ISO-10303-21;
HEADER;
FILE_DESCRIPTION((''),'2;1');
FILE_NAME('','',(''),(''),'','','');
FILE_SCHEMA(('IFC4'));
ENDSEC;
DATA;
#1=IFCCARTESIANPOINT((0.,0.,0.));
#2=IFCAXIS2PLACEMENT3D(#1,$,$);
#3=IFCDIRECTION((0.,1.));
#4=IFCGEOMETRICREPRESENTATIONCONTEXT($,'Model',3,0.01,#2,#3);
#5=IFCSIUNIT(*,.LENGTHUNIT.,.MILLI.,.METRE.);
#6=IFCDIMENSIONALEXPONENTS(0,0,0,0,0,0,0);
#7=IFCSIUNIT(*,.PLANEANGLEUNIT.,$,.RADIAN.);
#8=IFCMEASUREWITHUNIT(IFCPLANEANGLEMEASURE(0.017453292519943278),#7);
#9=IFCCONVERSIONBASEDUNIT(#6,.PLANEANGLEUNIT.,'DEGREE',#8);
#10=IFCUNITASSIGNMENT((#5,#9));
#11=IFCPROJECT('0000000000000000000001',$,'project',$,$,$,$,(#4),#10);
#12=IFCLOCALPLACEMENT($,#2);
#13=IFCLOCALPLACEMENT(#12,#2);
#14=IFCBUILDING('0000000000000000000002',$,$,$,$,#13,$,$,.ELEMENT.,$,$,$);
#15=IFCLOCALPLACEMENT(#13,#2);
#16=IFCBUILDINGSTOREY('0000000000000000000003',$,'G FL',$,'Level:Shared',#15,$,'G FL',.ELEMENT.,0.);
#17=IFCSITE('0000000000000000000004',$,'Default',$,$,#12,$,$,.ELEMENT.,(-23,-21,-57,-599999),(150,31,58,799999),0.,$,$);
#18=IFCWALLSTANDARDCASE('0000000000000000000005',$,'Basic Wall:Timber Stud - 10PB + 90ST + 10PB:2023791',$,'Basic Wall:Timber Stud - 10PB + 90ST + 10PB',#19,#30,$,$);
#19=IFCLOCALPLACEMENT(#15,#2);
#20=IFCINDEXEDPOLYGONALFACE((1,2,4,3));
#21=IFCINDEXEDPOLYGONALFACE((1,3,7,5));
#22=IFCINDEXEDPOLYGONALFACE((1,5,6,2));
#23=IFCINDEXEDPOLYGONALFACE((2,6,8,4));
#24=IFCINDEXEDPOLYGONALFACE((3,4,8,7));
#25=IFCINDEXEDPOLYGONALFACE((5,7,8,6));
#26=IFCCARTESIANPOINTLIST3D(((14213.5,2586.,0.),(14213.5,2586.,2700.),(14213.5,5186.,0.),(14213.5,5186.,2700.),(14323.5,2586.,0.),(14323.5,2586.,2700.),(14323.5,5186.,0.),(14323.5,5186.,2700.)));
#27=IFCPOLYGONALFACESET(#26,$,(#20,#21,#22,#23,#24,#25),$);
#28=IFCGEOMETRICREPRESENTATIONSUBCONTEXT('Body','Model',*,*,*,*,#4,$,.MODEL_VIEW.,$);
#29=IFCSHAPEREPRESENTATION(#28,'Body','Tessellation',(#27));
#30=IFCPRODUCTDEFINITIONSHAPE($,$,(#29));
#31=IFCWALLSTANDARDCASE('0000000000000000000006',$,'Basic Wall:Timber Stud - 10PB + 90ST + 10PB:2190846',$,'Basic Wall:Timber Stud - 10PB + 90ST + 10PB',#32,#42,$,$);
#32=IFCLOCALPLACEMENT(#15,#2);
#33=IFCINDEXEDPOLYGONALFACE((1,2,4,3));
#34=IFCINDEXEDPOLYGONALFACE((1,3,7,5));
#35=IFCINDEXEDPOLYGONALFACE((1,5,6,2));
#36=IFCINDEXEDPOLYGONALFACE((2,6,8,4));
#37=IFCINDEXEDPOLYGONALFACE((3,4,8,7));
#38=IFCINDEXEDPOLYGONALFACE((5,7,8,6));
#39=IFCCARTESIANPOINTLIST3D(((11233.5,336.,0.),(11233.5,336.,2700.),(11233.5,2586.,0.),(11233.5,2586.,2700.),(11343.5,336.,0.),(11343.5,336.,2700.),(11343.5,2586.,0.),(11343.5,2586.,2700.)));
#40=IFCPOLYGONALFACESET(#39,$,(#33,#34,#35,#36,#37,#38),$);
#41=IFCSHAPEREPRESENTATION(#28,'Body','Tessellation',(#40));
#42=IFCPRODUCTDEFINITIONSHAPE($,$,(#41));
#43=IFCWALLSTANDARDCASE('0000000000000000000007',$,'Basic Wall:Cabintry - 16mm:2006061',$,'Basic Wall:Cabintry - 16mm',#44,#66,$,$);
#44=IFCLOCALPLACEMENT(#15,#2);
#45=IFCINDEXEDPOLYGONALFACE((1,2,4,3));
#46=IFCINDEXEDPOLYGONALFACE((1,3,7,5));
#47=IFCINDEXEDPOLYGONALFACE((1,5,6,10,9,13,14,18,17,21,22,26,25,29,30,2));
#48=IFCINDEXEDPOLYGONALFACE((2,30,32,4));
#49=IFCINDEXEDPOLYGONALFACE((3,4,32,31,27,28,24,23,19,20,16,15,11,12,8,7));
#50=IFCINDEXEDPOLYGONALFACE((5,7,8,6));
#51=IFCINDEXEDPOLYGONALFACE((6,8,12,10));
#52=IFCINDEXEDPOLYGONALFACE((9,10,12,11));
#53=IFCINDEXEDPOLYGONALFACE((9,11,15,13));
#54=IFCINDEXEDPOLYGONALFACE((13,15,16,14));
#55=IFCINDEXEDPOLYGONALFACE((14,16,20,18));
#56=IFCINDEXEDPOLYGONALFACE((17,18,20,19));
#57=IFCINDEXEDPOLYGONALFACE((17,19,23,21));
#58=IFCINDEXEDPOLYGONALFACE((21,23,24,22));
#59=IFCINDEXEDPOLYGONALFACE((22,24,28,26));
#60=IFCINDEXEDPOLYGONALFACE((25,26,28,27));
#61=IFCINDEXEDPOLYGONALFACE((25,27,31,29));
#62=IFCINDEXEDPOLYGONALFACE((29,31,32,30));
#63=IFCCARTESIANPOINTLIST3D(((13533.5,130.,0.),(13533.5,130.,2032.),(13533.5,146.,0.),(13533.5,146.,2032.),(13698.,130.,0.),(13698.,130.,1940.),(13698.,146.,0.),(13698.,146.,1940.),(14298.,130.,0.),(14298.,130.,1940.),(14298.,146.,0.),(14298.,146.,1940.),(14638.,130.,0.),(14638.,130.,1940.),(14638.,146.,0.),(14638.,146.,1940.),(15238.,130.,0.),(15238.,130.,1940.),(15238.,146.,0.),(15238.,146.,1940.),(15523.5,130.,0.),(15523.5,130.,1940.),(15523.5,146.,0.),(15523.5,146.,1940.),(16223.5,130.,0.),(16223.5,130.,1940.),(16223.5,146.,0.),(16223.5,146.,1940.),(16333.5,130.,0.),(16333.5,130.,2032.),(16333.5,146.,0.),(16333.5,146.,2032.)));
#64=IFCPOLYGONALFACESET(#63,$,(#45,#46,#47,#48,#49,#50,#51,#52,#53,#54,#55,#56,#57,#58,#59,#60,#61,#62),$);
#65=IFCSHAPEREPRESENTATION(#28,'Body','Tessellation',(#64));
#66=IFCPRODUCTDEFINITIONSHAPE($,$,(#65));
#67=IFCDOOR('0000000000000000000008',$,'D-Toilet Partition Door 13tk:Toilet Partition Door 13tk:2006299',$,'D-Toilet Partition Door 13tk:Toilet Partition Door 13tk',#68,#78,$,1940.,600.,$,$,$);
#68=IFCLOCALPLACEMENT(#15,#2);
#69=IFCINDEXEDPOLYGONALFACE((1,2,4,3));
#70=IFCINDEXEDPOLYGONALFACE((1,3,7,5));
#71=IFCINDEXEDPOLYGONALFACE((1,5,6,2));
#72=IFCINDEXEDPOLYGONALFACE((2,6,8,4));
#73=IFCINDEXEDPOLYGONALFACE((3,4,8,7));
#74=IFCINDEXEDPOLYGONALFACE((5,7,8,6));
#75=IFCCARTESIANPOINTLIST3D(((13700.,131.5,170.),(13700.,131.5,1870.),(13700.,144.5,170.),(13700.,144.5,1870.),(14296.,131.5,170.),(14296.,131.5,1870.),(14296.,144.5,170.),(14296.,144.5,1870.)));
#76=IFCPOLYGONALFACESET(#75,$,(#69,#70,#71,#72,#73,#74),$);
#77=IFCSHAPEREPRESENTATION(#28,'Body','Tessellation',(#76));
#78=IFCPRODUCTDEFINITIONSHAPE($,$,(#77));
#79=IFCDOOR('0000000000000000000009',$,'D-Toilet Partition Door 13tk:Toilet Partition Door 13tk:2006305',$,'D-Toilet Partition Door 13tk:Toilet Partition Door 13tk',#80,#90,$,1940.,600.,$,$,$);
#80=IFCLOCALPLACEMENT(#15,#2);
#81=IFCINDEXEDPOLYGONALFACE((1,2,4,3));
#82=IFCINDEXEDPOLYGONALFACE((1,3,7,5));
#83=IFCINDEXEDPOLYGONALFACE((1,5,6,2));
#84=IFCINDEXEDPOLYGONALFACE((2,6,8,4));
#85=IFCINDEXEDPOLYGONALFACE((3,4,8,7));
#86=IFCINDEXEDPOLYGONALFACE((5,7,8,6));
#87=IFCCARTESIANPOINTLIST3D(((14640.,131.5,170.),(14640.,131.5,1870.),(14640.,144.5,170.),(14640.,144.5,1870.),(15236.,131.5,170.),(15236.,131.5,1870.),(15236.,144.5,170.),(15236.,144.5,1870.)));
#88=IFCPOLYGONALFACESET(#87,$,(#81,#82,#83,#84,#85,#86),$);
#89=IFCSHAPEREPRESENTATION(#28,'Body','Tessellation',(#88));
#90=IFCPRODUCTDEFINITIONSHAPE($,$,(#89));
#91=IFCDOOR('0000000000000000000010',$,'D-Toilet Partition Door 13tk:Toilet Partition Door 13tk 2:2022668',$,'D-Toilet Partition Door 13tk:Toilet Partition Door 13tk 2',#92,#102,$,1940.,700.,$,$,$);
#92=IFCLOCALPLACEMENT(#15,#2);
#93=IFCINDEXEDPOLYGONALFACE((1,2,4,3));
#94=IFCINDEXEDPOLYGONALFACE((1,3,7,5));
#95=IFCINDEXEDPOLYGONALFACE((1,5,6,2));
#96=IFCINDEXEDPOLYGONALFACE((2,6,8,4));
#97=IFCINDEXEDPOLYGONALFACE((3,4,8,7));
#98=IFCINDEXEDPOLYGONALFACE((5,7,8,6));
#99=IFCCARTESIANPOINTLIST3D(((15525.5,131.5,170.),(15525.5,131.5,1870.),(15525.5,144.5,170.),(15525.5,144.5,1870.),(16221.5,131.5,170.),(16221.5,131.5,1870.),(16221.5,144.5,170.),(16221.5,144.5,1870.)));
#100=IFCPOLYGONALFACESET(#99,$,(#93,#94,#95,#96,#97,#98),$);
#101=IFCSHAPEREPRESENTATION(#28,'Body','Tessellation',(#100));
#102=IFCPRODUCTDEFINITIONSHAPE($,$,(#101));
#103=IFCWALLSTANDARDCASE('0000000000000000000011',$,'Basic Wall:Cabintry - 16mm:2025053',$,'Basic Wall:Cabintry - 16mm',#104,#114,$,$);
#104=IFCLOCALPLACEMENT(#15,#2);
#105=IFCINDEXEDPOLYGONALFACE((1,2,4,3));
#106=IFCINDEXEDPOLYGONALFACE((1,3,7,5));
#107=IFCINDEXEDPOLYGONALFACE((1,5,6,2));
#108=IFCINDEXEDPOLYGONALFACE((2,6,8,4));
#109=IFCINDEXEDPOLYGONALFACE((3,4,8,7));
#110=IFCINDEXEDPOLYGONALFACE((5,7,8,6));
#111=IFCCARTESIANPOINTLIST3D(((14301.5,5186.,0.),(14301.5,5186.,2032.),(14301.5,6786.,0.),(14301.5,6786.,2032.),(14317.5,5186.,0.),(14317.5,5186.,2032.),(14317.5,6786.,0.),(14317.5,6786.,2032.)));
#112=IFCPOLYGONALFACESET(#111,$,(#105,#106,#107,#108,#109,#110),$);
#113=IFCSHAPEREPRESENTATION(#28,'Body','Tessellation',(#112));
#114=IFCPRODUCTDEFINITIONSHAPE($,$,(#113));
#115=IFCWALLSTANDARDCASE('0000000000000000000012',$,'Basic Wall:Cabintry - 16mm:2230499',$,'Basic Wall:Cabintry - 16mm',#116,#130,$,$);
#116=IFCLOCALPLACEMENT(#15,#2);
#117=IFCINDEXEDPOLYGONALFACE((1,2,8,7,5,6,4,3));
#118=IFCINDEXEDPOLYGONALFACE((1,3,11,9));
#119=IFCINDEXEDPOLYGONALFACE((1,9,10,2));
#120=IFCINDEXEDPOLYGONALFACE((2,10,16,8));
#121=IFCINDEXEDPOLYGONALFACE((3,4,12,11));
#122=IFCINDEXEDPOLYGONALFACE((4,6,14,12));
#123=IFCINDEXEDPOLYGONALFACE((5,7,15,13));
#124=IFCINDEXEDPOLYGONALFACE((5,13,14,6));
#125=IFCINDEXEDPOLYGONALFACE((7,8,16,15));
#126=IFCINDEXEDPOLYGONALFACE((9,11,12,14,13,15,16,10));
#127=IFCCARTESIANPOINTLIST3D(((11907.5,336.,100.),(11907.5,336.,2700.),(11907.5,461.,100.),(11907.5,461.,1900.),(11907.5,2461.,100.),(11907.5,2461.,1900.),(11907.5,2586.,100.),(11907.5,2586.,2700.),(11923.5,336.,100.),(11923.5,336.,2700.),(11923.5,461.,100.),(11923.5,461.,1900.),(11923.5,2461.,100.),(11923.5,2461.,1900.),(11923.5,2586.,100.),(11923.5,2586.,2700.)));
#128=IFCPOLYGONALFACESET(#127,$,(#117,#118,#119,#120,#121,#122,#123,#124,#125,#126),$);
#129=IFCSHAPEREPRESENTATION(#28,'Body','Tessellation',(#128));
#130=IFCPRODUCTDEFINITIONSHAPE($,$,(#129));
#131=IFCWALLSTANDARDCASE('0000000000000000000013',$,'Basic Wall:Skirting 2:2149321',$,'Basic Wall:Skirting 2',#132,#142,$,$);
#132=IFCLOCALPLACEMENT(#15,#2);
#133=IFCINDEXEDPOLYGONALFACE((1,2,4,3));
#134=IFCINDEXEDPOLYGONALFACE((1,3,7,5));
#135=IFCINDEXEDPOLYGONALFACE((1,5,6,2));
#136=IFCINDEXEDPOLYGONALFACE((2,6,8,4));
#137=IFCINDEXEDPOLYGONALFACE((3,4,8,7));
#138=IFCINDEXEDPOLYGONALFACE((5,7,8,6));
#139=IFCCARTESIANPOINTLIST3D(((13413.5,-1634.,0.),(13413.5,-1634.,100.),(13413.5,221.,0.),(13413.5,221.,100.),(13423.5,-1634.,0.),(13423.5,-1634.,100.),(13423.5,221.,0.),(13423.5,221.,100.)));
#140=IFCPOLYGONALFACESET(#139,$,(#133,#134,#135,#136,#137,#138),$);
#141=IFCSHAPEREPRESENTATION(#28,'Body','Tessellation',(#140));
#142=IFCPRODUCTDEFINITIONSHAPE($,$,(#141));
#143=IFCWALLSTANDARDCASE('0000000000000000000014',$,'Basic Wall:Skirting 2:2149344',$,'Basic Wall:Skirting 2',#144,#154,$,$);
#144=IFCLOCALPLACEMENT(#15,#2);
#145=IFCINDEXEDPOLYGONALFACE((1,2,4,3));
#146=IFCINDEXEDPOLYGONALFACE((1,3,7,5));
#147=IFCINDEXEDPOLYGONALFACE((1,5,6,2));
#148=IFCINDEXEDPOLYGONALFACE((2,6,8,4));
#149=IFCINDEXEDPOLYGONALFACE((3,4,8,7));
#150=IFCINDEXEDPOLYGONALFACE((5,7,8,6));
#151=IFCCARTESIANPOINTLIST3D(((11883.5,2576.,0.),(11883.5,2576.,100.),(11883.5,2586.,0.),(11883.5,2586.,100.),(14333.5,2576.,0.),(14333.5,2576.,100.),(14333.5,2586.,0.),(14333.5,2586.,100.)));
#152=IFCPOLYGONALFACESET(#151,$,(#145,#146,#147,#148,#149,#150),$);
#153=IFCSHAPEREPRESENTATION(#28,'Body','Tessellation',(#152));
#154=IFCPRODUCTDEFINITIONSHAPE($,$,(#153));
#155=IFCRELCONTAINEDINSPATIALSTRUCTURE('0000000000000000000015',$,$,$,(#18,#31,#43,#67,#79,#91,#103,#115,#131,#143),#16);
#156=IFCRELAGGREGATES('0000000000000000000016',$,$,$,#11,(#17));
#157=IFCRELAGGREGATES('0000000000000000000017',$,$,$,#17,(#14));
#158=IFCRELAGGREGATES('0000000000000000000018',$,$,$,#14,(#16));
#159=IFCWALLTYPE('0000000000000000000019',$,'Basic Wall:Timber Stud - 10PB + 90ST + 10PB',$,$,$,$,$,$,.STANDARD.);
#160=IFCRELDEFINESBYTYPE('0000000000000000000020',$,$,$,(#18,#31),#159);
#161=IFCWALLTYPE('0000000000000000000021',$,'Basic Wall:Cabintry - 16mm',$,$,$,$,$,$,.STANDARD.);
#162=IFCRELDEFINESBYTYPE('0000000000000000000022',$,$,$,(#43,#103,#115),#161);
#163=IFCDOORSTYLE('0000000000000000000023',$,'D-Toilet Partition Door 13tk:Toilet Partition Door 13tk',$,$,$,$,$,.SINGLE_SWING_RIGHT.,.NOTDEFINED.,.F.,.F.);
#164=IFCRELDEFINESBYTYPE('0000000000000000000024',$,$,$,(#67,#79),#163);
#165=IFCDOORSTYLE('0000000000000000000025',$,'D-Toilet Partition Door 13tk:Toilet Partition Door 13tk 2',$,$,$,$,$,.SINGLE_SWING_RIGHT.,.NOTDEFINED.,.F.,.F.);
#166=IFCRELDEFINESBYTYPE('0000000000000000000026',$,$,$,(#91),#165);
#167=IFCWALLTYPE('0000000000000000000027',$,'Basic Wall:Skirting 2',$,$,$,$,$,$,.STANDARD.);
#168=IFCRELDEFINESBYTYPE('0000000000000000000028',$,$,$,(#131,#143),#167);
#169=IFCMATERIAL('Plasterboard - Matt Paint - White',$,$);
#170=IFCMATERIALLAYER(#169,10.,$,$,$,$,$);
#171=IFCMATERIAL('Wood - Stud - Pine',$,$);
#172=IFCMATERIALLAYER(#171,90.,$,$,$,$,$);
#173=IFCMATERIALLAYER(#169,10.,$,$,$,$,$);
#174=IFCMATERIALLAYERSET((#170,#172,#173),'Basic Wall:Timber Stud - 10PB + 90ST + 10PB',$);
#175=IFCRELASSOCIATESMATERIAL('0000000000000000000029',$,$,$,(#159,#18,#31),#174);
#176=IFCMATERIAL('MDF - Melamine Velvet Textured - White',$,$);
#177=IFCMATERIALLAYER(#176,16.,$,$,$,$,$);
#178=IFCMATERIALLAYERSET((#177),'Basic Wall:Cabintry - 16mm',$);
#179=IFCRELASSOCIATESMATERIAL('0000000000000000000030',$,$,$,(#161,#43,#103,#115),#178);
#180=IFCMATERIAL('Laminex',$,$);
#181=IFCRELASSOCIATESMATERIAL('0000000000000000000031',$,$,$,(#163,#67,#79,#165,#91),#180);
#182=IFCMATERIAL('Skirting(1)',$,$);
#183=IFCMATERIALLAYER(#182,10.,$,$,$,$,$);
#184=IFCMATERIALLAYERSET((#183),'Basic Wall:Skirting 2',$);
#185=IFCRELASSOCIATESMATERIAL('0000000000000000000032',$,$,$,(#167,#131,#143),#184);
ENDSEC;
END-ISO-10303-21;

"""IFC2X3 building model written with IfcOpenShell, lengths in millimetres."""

from ifc_helpers import new_model, entity, si_unit, converted_unit, direction, frame, frame_2d, origin, place, context, subcontext, project, spatial, rectangle, extrude, source, transform, mapped, material, layer, layer_set, layer_usage, type_object, type_shapes, element, fill, save


model = new_model("IFC2X3")

# Units and contexts
model_context = context("Model", 3, precision=0.01, world=origin(), true_north=direction((0.0, 1.0)))
body_context = subcontext(model_context, "Body", "Model", "MODEL_VIEW")
ifc_project = project(units=[si_unit("LENGTHUNIT", "METRE", prefix="MILLI"), converted_unit("PLANEANGLEUNIT", "DEGREE", entity("IfcPlaneAngleMeasure", 0.017453292519943278), si_unit("PLANEANGLEUNIT", "RADIAN"), dimensions=[0, 0, 0, 0, 0, 0, 0])], contexts=[model_context])

# Site, building, storey
site_placement = place(None, origin())
site = spatial("IfcSite", under=ifc_project, at=site_placement, Name="Default", CompositionType="ELEMENT", RefLatitude=(-23, -21, -57, -599999), RefLongitude=(150, 31, 58, 799999), RefElevation=0.0)
building_placement = place(site_placement, origin())
building = spatial("IfcBuilding", under=site, at=building_placement, CompositionType="ELEMENT")
storey_placement = place(building_placement, origin())
storey = spatial("IfcBuildingStorey", under=building, at=storey_placement, Name="G FL", ObjectType="Level:Shared", LongName="G FL", CompositionType="ELEMENT", Elevation=0.0)

# Walls
ifc_material_1 = material(Name="Plasterboard - Matt Paint - White")
ifc_layer_1 = layer(ifc_material_1, 10.0)
ifc_material_2 = material(Name="Wood - Stud - Pine")
ifc_layer_2 = layer(ifc_material_2, 90.0)
ifc_layer_3 = layer(ifc_material_1, 10.0)
ifc_layer_set_1 = layer_set([ifc_layer_1, ifc_layer_2, ifc_layer_3], Name="Basic Wall:Timber Stud - 10PB + 90ST + 10PB")
ifc_layer_usage_1 = layer_usage(ifc_layer_set_1, "AXIS2", "POSITIVE", -55.0)
wall_type_1 = type_object("IfcWallType", Name="Basic Wall:Timber Stud - 10PB + 90ST + 10PB", PredefinedType="STANDARD", material=ifc_layer_set_1)
wall_1_placement = place(storey_placement, frame((14268.5, 5186.0, 0.0), z_axis=(0.0, 0.0, 1.0), x_axis=(0.0, -1.0, 0.0)))
element("IfcWallStandardCase", 1, at=wall_1_placement, inside=storey, type_object=wall_type_1, material=ifc_layer_usage_1, Name="Basic Wall:Timber Stud - 10PB + 90ST + 10PB:2023791", ObjectType="Basic Wall:Timber Stud - 10PB + 90ST + 10PB", context=body_context, shape_type="SweptSolid", body=[
    extrude(rectangle(XDim=2600.0, YDim=110.0, at=frame_2d((1300.0, 0.0), x_axis=(-1.0, 0.0))), origin(), (0.0, 0.0, 1.0), 2700.0),
])
ifc_layer_usage_2 = layer_usage(ifc_layer_set_1, "AXIS2", "NEGATIVE", 55.0)
wall_2_placement = place(storey_placement, frame((11288.5, 336.0, 0.0), z_axis=(0.0, 0.0, 1.0), x_axis=(0.0, 1.0, 0.0)))
element("IfcWallStandardCase", 2, at=wall_2_placement, inside=storey, type_object=wall_type_1, material=ifc_layer_usage_2, Name="Basic Wall:Timber Stud - 10PB + 90ST + 10PB:2190846", ObjectType="Basic Wall:Timber Stud - 10PB + 90ST + 10PB", context=body_context, shape_type="SweptSolid", body=[
    extrude(rectangle(XDim=2250.0, YDim=110.0, at=frame_2d((1125.0, 0.0), x_axis=(-1.0, 0.0))), origin(), (0.0, 0.0, 1.0), 2700.0),
])

# Wall, openings, doors
ifc_material_3 = material(Name="MDF - Melamine Velvet Textured - White")
ifc_layer_4 = layer(ifc_material_3, 16.0)
ifc_layer_set_2 = layer_set([ifc_layer_4], Name="Basic Wall:Cabintry - 16mm")
ifc_layer_usage_3 = layer_usage(ifc_layer_set_2, "AXIS2", "NEGATIVE", 8.0)
wall_type_2 = type_object("IfcWallType", Name="Basic Wall:Cabintry - 16mm", PredefinedType="STANDARD", material=ifc_layer_set_2)
wall_3_placement = place(storey_placement, frame((13533.5, 138.0, 0.0)))
wall_3 = element("IfcWallStandardCase", 3, at=wall_3_placement, inside=storey, type_object=wall_type_2, material=ifc_layer_usage_3, Name="Basic Wall:Cabintry - 16mm:2006061", ObjectType="Basic Wall:Cabintry - 16mm", context=body_context, shape_type="SweptSolid", body=[
    extrude(rectangle(XDim=2800.0, YDim=16.0, at=frame_2d((1400.0, 0.0), x_axis=(-1.0, 0.0))), origin(), (0.0, 0.0, 1.0), 2032.0),
])
opening_1_placement = place(wall_3_placement, frame((1704.5, 8.0, 0.0)))
opening_1 = element("IfcOpeningElement", 4, at=opening_1_placement, cuts=wall_3, ObjectType="Opening", context=body_context, shape_type="SweptSolid", body=[
    extrude(rectangle(XDim=1940.0, YDim=600.0, at=frame_2d((970.0, 300.0), x_axis=(1.0, 0.0))), frame((0.0, 0.0, 0.0), z_axis=(0.0, -1.0, 0.0), x_axis=(0.0, 0.0, 1.0)), (0.0, 0.0, 1.0), 16.0),
])
opening_2_placement = place(wall_3_placement, frame((764.5, 8.0, 0.0)))
opening_2 = element("IfcOpeningElement", 5, at=opening_2_placement, cuts=wall_3, ObjectType="Opening", context=body_context, shape_type="SweptSolid", body=[
    extrude(rectangle(XDim=1940.0, YDim=600.0, at=frame_2d((970.0, 300.0), x_axis=(1.0, 0.0))), frame((0.0, 0.0, 0.0), z_axis=(0.0, -1.0, 0.0), x_axis=(0.0, 0.0, 1.0)), (0.0, 0.0, 1.0), 16.0),
])
opening_3_placement = place(wall_3_placement, frame((1990.0, -8.0, 0.0)))
opening_3 = element("IfcOpeningElement", 6, at=opening_3_placement, cuts=wall_3, ObjectType="Opening", context=body_context, shape_type="SweptSolid", body=[
    extrude(rectangle(XDim=1940.0, YDim=700.0, at=frame_2d((970.0, 350.0), x_axis=(1.0, 0.0))), frame((0.0, 0.0, 0.0), z_axis=(0.0, 1.0, 0.0), x_axis=(0.0, 0.0, 1.0)), (0.0, 0.0, 1.0), 16.0),
])
ifc_material_4 = material(Name="Laminex")
door_style_1 = type_object("IfcDoorStyle", Name="D-Toilet Partition Door 13tk:Toilet Partition Door 13tk", ConstructionType="NOTDEFINED", OperationType="SINGLE_SWING_RIGHT", ParameterTakesPrecedence=False, Sizeable=False, material=ifc_material_4)
shared_shape_1 = source(origin(), body_context, "Body", "SweptSolid", [
    extrude(rectangle(XDim=596.0, YDim=13.0, at=frame_2d((0.0, 0.0), x_axis=(1.0, 0.0))), frame((300.0, 8.0, 170.0)), (0.0, 0.0, 1.0), 1700.0),
])
type_shapes(door_style_1, [shared_shape_1])
door_1_placement = place(opening_2_placement, frame((0.0, 0.0, 0.0), z_axis=(0.0, 0.0, 1.0), x_axis=(-1.0, 0.0, 0.0)))
door_1 = element("IfcDoor", 7, at=door_1_placement, inside=storey, type_object=door_style_1, material=ifc_material_4, Name="D-Toilet Partition Door 13tk:Toilet Partition Door 13tk:2006299", ObjectType="D-Toilet Partition Door 13tk:Toilet Partition Door 13tk", OverallHeight=1940.0, OverallWidth=600.0, context=body_context, shape_type="MappedRepresentation", body=[
    mapped(shared_shape_1, transform((0.0, 0.0, 0.0), scale=1.0)),
])
fill(opening_2, door_1)
door_2_placement = place(opening_1_placement, frame((0.0, 0.0, 0.0), z_axis=(0.0, 0.0, 1.0), x_axis=(-1.0, 0.0, 0.0)))
door_2 = element("IfcDoor", 8, at=door_2_placement, inside=storey, type_object=door_style_1, material=ifc_material_4, Name="D-Toilet Partition Door 13tk:Toilet Partition Door 13tk:2006305", ObjectType="D-Toilet Partition Door 13tk:Toilet Partition Door 13tk", OverallHeight=1940.0, OverallWidth=600.0, context=body_context, shape_type="MappedRepresentation", body=[
    mapped(shared_shape_1, transform((0.0, 0.0, 0.0), scale=1.0)),
])
fill(opening_1, door_2)
door_style_2 = type_object("IfcDoorStyle", Name="D-Toilet Partition Door 13tk:Toilet Partition Door 13tk 2", ConstructionType="NOTDEFINED", OperationType="SINGLE_SWING_RIGHT", ParameterTakesPrecedence=False, Sizeable=False, material=ifc_material_4)
shared_shape_2 = source(origin(), body_context, "Body", "SweptSolid", [
    extrude(rectangle(XDim=696.0, YDim=13.0, at=frame_2d((0.0, 0.0), x_axis=(1.0, 0.0))), frame((450.0, 8.0, 170.0)), (0.0, 0.0, 1.0), 1700.0),
])
type_shapes(door_style_2, [shared_shape_2])
door_3_placement = place(opening_3_placement, frame((-100.0, 0.0, 0.0)))
door_3 = element("IfcDoor", 9, at=door_3_placement, inside=storey, type_object=door_style_2, material=ifc_material_4, Name="D-Toilet Partition Door 13tk:Toilet Partition Door 13tk 2:2022668", ObjectType="D-Toilet Partition Door 13tk:Toilet Partition Door 13tk 2", OverallHeight=1940.0, OverallWidth=700.0, context=body_context, shape_type="MappedRepresentation", body=[
    mapped(shared_shape_2, transform((0.0, 0.0, 0.0), scale=1.0)),
])
fill(opening_3, door_3)

# Wall
ifc_layer_usage_4 = layer_usage(ifc_layer_set_2, "AXIS2", "NEGATIVE", 8.0)
wall_4_placement = place(storey_placement, frame((14309.5, 5186.0, 0.0), z_axis=(0.0, 0.0, 1.0), x_axis=(0.0, 1.0, 0.0)))
element("IfcWallStandardCase", 10, at=wall_4_placement, inside=storey, type_object=wall_type_2, material=ifc_layer_usage_4, Name="Basic Wall:Cabintry - 16mm:2025053", ObjectType="Basic Wall:Cabintry - 16mm", context=body_context, shape_type="SweptSolid", body=[
    extrude(rectangle(XDim=1600.0, YDim=16.0, at=frame_2d((800.0, 0.0), x_axis=(-1.0, 0.0))), origin(), (0.0, 0.0, 1.0), 2032.0),
])

# Wall, opening
ifc_layer_usage_5 = layer_usage(ifc_layer_set_2, "AXIS2", "NEGATIVE", 8.0)
wall_5_placement = place(storey_placement, frame((11915.5, 336.0, 100.0), z_axis=(0.0, 0.0, 1.0), x_axis=(0.0, 1.0, 0.0)))
wall_5 = element("IfcWallStandardCase", 11, at=wall_5_placement, inside=storey, type_object=wall_type_2, material=ifc_layer_usage_5, Name="Basic Wall:Cabintry - 16mm:2230499", ObjectType="Basic Wall:Cabintry - 16mm", context=body_context, shape_type="SweptSolid", body=[
    extrude(rectangle(XDim=2250.0, YDim=16.0, at=frame_2d((1125.0, 0.0), x_axis=(-1.0, 0.0))), origin(), (0.0, 0.0, 1.0), 2600.0),
])
opening_4_placement = place(wall_5_placement, origin())
element("IfcOpeningElement", 12, at=opening_4_placement, cuts=wall_5, ObjectType="Opening", context=body_context, shape_type="SweptSolid", body=[
    extrude(rectangle(XDim=1800.0, YDim=2000.0, at=frame_2d((0.0, 0.0), x_axis=(0.0, 1.0))), frame((1125.0, 8.0, 900.0), z_axis=(0.0, -1.0, 0.0), x_axis=(1.0, 0.0, 0.0)), (0.0, 0.0, 1.0), 16.0),
])
ifc_material_5 = material(Name="Skirting(1)")
ifc_layer_5 = layer(ifc_material_5, 10.0)
ifc_layer_set_3 = layer_set([ifc_layer_5], Name="Basic Wall:Skirting 2")
wall_type_3 = type_object("IfcWallType", Name="Basic Wall:Skirting 2", PredefinedType="STANDARD", material=ifc_layer_set_3)

# Walls
ifc_layer_usage_6 = layer_usage(ifc_layer_set_3, "AXIS2", "NEGATIVE", 5.0)
wall_6_placement = place(storey_placement, frame((13418.5, 221.0, 0.0), z_axis=(0.0, 0.0, 1.0), x_axis=(0.0, -1.0, 0.0)))
element("IfcWallStandardCase", 13, at=wall_6_placement, inside=storey, type_object=wall_type_3, material=ifc_layer_usage_6, Name="Basic Wall:Skirting 2:2149321", ObjectType="Basic Wall:Skirting 2", context=body_context, shape_type="SweptSolid", body=[
    extrude(rectangle(XDim=1855.0, YDim=10.0, at=frame_2d((927.5, 0.0), x_axis=(-1.0, 0.0))), origin(), (0.0, 0.0, 1.0), 100.0),
])
ifc_layer_usage_7 = layer_usage(ifc_layer_set_3, "AXIS2", "NEGATIVE", 5.0)
wall_7_placement = place(storey_placement, frame((11883.5, 2581.0, 0.0)))
element("IfcWallStandardCase", 14, at=wall_7_placement, inside=storey, type_object=wall_type_3, material=ifc_layer_usage_7, Name="Basic Wall:Skirting 2:2149344", ObjectType="Basic Wall:Skirting 2", context=body_context, shape_type="SweptSolid", body=[
    extrude(rectangle(XDim=2450.0, YDim=10.0, at=frame_2d((1225.0, 0.0), x_axis=(-1.0, 0.0))), origin(), (0.0, 0.0, 1.0), 100.0),
])

save(model, "model.ifc")
